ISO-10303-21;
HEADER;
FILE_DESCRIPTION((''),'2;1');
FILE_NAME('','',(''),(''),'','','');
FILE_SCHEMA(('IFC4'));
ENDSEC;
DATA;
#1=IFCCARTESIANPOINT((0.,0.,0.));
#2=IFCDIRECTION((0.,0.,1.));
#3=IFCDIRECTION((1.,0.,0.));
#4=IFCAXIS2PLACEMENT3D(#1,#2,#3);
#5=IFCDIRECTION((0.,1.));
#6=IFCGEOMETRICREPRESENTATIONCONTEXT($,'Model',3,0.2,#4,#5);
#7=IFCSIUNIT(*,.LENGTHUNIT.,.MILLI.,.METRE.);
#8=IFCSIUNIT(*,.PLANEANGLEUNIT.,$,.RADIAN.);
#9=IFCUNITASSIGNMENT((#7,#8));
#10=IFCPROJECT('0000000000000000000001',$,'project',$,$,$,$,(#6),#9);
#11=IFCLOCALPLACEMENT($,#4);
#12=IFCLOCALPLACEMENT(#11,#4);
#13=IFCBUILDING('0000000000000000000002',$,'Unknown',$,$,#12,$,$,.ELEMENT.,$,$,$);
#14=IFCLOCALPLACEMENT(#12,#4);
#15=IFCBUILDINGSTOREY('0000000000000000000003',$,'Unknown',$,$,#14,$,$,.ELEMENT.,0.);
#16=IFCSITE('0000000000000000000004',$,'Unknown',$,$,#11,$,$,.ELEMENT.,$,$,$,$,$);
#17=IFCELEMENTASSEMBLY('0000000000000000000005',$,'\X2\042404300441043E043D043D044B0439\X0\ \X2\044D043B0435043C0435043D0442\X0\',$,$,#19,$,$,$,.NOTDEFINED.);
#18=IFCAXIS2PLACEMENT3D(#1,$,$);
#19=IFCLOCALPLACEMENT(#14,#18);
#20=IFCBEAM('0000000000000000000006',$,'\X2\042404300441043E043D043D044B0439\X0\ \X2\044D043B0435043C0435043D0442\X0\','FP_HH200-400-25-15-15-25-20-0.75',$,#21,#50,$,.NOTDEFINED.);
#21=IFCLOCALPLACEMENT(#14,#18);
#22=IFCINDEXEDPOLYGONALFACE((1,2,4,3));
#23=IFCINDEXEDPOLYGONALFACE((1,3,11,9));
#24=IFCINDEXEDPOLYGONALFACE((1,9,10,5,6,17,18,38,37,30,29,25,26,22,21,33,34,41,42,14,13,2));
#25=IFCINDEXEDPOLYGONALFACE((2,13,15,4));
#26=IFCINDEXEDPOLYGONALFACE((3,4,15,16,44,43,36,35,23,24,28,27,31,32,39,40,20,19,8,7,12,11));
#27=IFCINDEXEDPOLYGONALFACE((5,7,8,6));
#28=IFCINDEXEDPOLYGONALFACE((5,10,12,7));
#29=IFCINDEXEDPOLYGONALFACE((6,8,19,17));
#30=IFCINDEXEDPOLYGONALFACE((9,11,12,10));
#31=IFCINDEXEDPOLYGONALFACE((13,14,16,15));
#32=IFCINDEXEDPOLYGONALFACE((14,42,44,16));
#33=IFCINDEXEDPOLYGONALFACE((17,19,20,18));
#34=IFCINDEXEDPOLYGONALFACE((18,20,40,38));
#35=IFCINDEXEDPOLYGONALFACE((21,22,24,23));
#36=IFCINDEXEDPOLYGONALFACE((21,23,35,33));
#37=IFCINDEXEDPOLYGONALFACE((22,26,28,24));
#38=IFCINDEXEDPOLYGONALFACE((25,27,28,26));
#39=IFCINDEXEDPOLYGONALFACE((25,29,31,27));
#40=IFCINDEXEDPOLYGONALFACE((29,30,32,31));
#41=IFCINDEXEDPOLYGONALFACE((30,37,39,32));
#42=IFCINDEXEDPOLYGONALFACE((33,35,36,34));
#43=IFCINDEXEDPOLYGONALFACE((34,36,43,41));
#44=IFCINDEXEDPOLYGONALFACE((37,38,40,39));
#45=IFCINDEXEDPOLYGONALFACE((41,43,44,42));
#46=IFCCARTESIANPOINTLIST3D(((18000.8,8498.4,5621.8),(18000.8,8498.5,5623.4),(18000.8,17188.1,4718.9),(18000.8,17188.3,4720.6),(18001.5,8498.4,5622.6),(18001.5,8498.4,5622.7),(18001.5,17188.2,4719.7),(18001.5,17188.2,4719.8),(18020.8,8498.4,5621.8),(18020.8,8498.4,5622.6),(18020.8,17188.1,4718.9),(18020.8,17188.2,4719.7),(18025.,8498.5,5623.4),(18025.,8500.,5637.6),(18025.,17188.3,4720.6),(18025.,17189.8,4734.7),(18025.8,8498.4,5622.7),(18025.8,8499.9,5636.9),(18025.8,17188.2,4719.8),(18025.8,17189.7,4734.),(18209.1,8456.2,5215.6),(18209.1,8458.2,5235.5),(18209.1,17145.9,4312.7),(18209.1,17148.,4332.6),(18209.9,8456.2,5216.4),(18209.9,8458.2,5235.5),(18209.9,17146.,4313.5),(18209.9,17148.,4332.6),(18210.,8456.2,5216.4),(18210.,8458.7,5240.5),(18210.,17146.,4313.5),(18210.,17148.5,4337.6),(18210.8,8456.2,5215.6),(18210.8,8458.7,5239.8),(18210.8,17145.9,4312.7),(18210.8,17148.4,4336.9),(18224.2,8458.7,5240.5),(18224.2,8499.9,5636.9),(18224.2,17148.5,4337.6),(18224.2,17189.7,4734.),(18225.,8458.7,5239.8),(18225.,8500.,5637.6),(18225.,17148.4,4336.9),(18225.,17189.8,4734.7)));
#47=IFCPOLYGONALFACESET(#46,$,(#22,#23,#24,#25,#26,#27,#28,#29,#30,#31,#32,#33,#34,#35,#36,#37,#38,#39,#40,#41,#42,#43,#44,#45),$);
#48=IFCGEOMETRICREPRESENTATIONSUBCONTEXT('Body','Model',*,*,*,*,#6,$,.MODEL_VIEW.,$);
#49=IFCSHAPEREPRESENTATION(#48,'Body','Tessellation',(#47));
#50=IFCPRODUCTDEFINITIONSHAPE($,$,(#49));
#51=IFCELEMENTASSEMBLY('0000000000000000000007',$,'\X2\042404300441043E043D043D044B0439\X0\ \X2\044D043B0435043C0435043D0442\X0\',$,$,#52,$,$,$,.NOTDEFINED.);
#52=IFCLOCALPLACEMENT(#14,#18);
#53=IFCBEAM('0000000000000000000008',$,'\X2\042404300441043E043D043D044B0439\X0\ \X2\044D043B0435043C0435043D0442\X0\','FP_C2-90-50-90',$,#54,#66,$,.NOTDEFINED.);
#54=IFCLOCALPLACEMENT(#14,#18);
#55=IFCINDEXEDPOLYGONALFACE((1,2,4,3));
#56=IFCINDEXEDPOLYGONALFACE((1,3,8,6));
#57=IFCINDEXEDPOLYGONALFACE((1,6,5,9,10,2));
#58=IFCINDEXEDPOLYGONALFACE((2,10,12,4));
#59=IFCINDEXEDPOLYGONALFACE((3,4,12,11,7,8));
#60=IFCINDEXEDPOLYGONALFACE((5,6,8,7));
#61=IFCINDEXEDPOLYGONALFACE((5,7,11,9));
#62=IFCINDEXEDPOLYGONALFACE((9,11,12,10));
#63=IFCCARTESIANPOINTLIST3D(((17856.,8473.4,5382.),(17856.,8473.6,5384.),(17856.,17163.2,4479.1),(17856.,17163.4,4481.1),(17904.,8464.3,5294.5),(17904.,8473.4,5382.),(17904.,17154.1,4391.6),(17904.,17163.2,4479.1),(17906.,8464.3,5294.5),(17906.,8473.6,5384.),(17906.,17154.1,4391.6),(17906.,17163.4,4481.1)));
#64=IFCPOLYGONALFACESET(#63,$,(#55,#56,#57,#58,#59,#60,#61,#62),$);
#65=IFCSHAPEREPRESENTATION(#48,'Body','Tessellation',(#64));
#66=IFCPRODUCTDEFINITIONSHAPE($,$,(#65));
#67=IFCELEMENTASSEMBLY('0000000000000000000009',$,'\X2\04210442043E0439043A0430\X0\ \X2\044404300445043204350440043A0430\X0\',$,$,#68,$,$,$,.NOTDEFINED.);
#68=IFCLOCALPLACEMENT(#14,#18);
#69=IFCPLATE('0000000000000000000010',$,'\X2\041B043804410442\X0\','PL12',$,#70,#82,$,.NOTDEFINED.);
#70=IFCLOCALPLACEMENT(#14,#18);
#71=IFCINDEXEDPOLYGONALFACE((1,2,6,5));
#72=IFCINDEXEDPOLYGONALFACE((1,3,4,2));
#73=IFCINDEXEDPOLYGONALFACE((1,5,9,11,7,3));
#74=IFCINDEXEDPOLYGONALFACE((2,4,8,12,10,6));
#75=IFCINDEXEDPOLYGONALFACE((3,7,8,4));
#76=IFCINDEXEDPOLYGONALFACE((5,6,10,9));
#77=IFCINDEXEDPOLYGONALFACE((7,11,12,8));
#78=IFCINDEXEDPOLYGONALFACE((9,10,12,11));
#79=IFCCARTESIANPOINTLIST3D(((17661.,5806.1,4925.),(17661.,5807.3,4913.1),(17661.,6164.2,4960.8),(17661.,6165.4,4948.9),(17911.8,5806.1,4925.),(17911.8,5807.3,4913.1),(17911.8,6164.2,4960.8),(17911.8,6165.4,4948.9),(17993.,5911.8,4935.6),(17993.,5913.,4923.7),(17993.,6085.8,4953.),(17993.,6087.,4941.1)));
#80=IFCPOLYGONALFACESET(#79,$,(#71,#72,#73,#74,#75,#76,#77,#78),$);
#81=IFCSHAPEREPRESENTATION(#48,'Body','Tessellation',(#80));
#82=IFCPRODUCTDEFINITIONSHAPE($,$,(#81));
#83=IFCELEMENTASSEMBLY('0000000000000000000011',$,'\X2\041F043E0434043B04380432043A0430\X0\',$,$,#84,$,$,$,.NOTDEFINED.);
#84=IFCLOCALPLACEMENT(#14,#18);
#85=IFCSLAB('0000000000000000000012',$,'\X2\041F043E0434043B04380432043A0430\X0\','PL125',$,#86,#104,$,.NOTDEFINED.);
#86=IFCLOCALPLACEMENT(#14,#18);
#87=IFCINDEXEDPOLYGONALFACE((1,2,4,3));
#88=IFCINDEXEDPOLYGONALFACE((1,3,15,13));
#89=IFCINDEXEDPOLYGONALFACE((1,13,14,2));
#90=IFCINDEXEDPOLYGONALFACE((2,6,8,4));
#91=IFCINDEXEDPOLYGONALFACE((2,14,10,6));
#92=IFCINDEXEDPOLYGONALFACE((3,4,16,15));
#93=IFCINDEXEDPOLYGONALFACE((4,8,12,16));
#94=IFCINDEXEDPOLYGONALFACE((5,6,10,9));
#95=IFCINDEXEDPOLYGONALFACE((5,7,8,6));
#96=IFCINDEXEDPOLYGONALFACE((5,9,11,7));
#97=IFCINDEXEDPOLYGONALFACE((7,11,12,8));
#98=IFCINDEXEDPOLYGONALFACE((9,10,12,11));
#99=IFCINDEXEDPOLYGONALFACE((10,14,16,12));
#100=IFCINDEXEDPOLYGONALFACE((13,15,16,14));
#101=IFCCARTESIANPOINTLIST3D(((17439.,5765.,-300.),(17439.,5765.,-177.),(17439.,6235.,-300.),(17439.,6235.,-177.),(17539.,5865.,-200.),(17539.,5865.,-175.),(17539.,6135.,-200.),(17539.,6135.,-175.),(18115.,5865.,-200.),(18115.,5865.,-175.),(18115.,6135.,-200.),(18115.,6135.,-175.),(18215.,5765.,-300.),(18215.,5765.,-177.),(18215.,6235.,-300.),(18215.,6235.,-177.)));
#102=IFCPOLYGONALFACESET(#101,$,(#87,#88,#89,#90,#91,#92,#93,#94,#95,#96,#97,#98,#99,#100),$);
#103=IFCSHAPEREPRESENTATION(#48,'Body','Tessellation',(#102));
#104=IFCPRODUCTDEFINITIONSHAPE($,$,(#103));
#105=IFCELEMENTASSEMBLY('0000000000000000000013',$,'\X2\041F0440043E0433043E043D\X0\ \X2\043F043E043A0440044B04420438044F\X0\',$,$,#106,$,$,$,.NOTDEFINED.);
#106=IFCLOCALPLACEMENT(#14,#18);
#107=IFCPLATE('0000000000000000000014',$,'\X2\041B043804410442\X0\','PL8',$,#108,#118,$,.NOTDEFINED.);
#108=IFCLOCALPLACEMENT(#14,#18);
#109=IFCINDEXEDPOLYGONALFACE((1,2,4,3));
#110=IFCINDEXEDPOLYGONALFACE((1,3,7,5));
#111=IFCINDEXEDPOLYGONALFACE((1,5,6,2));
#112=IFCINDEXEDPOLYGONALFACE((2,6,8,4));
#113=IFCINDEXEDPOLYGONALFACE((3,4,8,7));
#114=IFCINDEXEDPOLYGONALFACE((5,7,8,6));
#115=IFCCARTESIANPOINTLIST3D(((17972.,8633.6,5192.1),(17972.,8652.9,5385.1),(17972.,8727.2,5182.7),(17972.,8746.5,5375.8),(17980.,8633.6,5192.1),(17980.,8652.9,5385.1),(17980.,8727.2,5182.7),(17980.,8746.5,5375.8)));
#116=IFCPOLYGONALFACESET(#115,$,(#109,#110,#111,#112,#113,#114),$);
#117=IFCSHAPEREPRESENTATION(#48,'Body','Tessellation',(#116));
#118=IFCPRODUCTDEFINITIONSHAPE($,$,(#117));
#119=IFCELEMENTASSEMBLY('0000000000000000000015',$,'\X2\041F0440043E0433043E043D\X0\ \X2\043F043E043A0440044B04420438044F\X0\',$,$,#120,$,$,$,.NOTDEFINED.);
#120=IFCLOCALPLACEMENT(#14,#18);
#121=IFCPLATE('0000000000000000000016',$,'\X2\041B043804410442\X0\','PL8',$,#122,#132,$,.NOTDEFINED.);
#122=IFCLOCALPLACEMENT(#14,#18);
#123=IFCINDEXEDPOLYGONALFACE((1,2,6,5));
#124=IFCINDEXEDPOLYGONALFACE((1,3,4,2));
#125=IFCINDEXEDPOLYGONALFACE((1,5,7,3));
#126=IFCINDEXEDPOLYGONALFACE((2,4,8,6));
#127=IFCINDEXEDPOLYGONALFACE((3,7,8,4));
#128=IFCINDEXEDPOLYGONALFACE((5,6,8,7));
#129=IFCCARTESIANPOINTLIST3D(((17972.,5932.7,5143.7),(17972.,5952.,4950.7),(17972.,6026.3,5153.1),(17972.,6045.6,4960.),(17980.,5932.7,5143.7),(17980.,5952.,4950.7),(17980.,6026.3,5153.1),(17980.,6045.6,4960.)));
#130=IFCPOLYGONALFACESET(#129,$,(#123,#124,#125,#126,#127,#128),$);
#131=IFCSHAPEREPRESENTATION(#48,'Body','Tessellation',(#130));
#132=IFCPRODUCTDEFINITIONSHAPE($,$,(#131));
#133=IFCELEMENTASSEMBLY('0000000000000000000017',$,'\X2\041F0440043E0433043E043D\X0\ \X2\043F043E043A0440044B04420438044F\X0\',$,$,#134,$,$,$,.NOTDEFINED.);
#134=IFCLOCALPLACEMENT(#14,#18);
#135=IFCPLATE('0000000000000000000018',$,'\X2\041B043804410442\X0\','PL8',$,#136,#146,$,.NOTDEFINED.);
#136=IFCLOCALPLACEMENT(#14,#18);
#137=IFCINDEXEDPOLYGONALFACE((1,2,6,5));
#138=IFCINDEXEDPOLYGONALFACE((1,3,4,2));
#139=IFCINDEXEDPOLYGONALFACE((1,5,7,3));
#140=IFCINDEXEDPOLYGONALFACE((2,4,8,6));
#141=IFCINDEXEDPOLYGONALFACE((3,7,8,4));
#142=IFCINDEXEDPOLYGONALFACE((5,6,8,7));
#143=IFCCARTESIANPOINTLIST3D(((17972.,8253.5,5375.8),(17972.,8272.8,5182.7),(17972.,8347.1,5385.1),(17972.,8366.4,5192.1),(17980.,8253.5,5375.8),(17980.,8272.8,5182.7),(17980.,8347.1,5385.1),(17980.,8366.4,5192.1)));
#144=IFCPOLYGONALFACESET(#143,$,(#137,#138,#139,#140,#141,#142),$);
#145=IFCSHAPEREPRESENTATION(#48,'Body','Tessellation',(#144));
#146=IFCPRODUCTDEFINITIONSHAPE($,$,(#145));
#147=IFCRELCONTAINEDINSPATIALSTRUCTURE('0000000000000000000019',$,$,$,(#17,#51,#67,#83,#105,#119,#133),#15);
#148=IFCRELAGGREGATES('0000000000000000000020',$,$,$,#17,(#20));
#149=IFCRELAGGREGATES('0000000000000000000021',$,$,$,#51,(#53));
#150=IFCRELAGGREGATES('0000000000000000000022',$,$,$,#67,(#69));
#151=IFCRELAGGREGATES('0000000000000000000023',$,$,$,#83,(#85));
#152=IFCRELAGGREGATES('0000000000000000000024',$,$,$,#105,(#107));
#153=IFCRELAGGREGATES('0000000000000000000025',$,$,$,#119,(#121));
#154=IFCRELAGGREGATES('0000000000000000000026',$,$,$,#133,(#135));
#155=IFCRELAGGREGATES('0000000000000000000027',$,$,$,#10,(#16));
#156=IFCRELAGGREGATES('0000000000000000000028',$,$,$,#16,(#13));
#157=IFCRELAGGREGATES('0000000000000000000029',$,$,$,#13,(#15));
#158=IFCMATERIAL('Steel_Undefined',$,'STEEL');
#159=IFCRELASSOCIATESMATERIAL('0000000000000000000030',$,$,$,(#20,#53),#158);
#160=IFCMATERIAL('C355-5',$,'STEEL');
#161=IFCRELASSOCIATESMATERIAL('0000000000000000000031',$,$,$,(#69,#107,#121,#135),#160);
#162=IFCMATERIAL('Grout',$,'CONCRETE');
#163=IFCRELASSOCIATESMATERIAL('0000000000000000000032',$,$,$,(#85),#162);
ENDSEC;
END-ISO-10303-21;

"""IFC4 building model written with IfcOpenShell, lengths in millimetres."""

from ifc_helpers import new_model, si_unit, direction, frame, origin_with_axes, place, context, subcontext, project, spatial, line, indexed_curve, outline, extrude, material, element, aggregate, save


model = new_model("IFC4")

# Units and contexts
model_context = context("Model", 3, precision=0.2, world=origin_with_axes(), true_north=direction((0.0, 1.0)))
body_context = subcontext(model_context, "Body", "Model", "MODEL_VIEW")
ifc_project = project(units=[si_unit("LENGTHUNIT", "METRE", prefix="MILLI"), si_unit("PLANEANGLEUNIT", "RADIAN")], contexts=[model_context])

# Site, building, storey
site_placement = place(None, origin_with_axes())
site = spatial("IfcSite", under=ifc_project, at=site_placement, Name="Unknown", CompositionType="ELEMENT")
building_placement = place(site_placement, origin_with_axes())
building = spatial("IfcBuilding", under=site, at=building_placement, Name="Unknown", CompositionType="ELEMENT")
storey_placement = place(building_placement, origin_with_axes())
storey = spatial("IfcBuildingStorey", under=building, at=storey_placement, Name="Unknown", CompositionType="ELEMENT", Elevation=0.0)

# Shared definitions
ifc_material_1 = material(Name="C355-5", Category="STEEL")

# Element assemblies, beams
assembly_1_placement = place(storey_placement, frame((18125.0, 8479.3, 5438.7), z_axis=(0.0, 0.103345, 0.994646), x_axis=(0.0, 0.994646, -0.103345)))
assembly_1 = element("IfcElementAssembly", 1, at=assembly_1_placement, inside=storey, Name="Фасонный элемент", PredefinedType="NOTDEFINED")
ifc_material_2 = material(Name="Steel_Undefined", Category="STEEL")
beam_1_placement = place(assembly_1_placement, origin_with_axes())
beam_1 = element("IfcBeam", 2, at=beam_1_placement, material=ifc_material_2, Name="Фасонный элемент", Description="FP_HH200-400-25-15-15-25-20-0.75", PredefinedType="NOTDEFINED", context=body_context, shape_type="SolidModel", body=[
    extrude(outline(indexed_curve([(-200.0, -100.0), (200.0, -100.0), (200.0, 100.0), (185.8, 100.0), (185.8, 124.2), (184.1, 124.2), (184.1, 104.2), (184.9, 104.2), (184.9, 123.5), (185.0, 123.5), (185.0, 99.2), (199.2, 99.2), (199.2, -99.2), (-199.2, -99.2), (-199.2, -85.0), (-223.5, -85.0), (-223.5, -84.9), (-204.2, -84.9), (-204.2, -84.1), (-224.2, -84.1), (-224.2, -85.8), (-200.0, -85.8)], segments=[line(1, 2, 3, 4, 5, 6, 7, 8, 9, 10, 11, 12, 13, 14, 15, 16, 17, 18, 19, 20, 21, 22, 1)])), frame((0.0, 0.0, 0.0), z_axis=(-1.0, 0.0, 0.0), x_axis=(0.0, 0.0, 1.0)), (0.0, 0.0, -1.0), 8736.6),
])
aggregate(assembly_1, [beam_1])
assembly_2_placement = place(storey_placement, frame((17905.0, 8469.0, 5339.2), z_axis=(0.0, 0.103345, 0.994646), x_axis=(0.0, 0.994646, -0.103345)))
assembly_2 = element("IfcElementAssembly", 3, at=assembly_2_placement, inside=storey, Name="Фасонный элемент", PredefinedType="NOTDEFINED")
beam_2_placement = place(assembly_2_placement, origin_with_axes())
beam_2 = element("IfcBeam", 4, at=beam_2_placement, material=ifc_material_2, Name="Фасонный элемент", Description="FP_C2-90-50-90", PredefinedType="NOTDEFINED", context=body_context, shape_type="SolidModel", body=[
    extrude(outline(indexed_curve([(-45.0, -1.0), (45.0, -1.0), (45.0, 49.0), (43.0, 49.0), (43.0, 1.0), (-45.0, 1.0)], segments=[line(1, 2, 3, 4, 5, 6, 1)])), frame((0.0, 0.0, 0.0), z_axis=(-1.0, 0.0, 0.0), x_axis=(0.0, 0.0, 1.0)), (0.0, 0.0, -1.0), 8736.6),
])
aggregate(assembly_2, [beam_2])

# Element assembly, plate
assembly_3_placement = place(storey_placement, frame((17827.0, 6000.0, -200.0), z_axis=(0.0, -1.0, 0.0), x_axis=(0.0, 0.0, 1.0)))
assembly_3 = element("IfcElementAssembly", 5, at=assembly_3_placement, inside=storey, Name="Стойка фахверка", PredefinedType="NOTDEFINED")
plate_1_placement = place(assembly_3_placement, frame((5154.9, -166.0, -164.8), z_axis=(0.995037, 0.0, 0.099504), x_axis=(0.0, 1.0, 0.0)))
plate_1 = element("IfcPlate", 6, at=plate_1_placement, material=ifc_material_1, Name="Лист", Description="PL12", PredefinedType="NOTDEFINED", context=body_context, shape_type="SolidModel", body=[
    extrude(outline(indexed_curve([(0.0, 78.8), (81.2, 0.0), (332.0, 0.0), (332.0, 359.9), (81.2, 359.9), (0.0, 253.7)], segments=[line(1, 2, 3, 4, 5, 6, 1)])), frame((0.0, 0.0, 6.0), z_axis=(0.0, 0.0, 1.0), x_axis=(1.0, 0.0, 0.0)), (0.0, 0.0, -1.0), 12.0),
])
aggregate(assembly_3, [plate_1])

# Element assembly, slab, voiding features
assembly_4_placement = place(storey_placement, frame((18215.0, 6235.0, -237.5), z_axis=(0.0, 0.0, -1.0), x_axis=(0.0, -1.0, 0.0)))
assembly_4 = element("IfcElementAssembly", 7, at=assembly_4_placement, inside=storey, Name="Подливка", PredefinedType="NOTDEFINED")
ifc_material_3 = material(Name="Grout", Category="CONCRETE")
slab_placement = place(assembly_4_placement, origin_with_axes())
slab = element("IfcSlab", 8, at=slab_placement, material=ifc_material_3, Name="Подливка", Description="PL125", PredefinedType="NOTDEFINED", context=body_context, shape_type="SolidModel", body=[
    extrude(outline(indexed_curve([(0.0, 0.0), (470.0, 0.0), (470.0, 776.0), (0.0, 776.0)], segments=[line(1, 2, 3, 4, 1)])), frame((0.0, 0.0, 62.5), z_axis=(0.0, 0.0, 1.0), x_axis=(1.0, 0.0, 0.0)), (0.0, 0.0, -1.0), 125.0),
])
voiding_feature_1_placement = place(slab_placement, frame((235.0, 0.0, -62.5), z_axis=(1.0, 0.0, 0.0), x_axis=(0.0, 1.0, 0.0)))
element("IfcVoidingFeature", 9, at=voiding_feature_1_placement, cuts=slab, Name="PLATE", PredefinedType="HOLE", context=body_context, shape_type="SolidModel", body=[
    extrude(outline(indexed_curve([(0.0, 0.0), (100.0, 0.0), (0.0, 2.0)], segments=[line(1, 2, 3, 1)])), frame((0.0, 0.0, 247.0), z_axis=(0.0, 0.0, 1.0), x_axis=(1.0, 0.0, 0.0)), (0.0, 0.0, -1.0), 494.0),
])
voiding_feature_2_placement = place(slab_placement, frame((235.0, 776.0, -62.5), z_axis=(-1.0, 0.0, 0.0), x_axis=(0.0, -1.0, 0.0)))
element("IfcVoidingFeature", 10, at=voiding_feature_2_placement, cuts=slab, Name="PLATE", PredefinedType="HOLE", context=body_context, shape_type="SolidModel", body=[
    extrude(outline(indexed_curve([(0.0, 0.0), (100.0, 0.0), (0.0, 2.0)], segments=[line(1, 2, 3, 1)])), frame((0.0, 0.0, 247.0), z_axis=(0.0, 0.0, 1.0), x_axis=(1.0, 0.0, 0.0)), (0.0, 0.0, -1.0), 494.0),
])
voiding_feature_3_placement = place(slab_placement, frame((470.0, 388.0, -62.5), z_axis=(0.0, 1.0, 0.0), x_axis=(-1.0, 0.0, 0.0)))
element("IfcVoidingFeature", 11, at=voiding_feature_3_placement, cuts=slab, Name="PLATE", PredefinedType="HOLE", context=body_context, shape_type="SolidModel", body=[
    extrude(outline(indexed_curve([(0.0, 0.0), (100.0, 0.0), (0.0, 2.0)], segments=[line(1, 2, 3, 1)])), frame((0.0, 0.0, 400.0), z_axis=(0.0, 0.0, 1.0), x_axis=(1.0, 0.0, 0.0)), (0.0, 0.0, -1.0), 800.0),
])
voiding_feature_4_placement = place(slab_placement, frame((0.0, 388.0, -62.5), z_axis=(0.0, -1.0, 0.0), x_axis=(1.0, 0.0, 0.0)))
element("IfcVoidingFeature", 12, at=voiding_feature_4_placement, cuts=slab, Name="PLATE", PredefinedType="HOLE", context=body_context, shape_type="SolidModel", body=[
    extrude(outline(indexed_curve([(0.0, 0.0), (100.0, 0.0), (0.0, 2.0)], segments=[line(1, 2, 3, 1)])), frame((0.0, 0.0, 400.0), z_axis=(0.0, 0.0, 1.0), x_axis=(1.0, 0.0, 0.0)), (0.0, 0.0, -1.0), 800.0),
])
voiding_feature_5_placement = place(slab_placement, frame((235.0, 676.0, -50.0), z_axis=(0.0, 0.0, 1.0), x_axis=(0.0, -1.0, 0.0)))
element("IfcVoidingFeature", 13, at=voiding_feature_5_placement, cuts=slab, Name="Пластина", PredefinedType="HOLE", context=body_context, shape_type="SolidModel", body=[
    extrude(outline(indexed_curve([(-12.5, -135.0), (12.5, -135.0), (12.5, 135.0), (-12.5, 135.0)], segments=[line(1, 2, 3, 4, 1)])), frame((0.0, 0.0, 0.0), z_axis=(-1.0, 0.0, 0.0), x_axis=(0.0, 0.0, 1.0)), (0.0, 0.0, -1.0), 576.0),
])
aggregate(assembly_4, [slab])

# Element assembly, plate
assembly_5_placement = place(storey_placement, frame((18000.0, 8690.0, 5283.9), z_axis=(0.0, -0.995037, 0.099504), x_axis=(-1.0, 0.0, 0.0)))
assembly_5 = element("IfcElementAssembly", 14, at=assembly_5_placement, inside=storey, Name="Прогон покрытия", PredefinedType="NOTDEFINED")
plate_2_placement = place(assembly_5_placement, frame((24.0, 97.0, 47.0), z_axis=(-1.0, 0.0, 0.0), x_axis=(0.0, 0.0, -1.0)))
plate_2 = element("IfcPlate", 15, at=plate_2_placement, material=ifc_material_1, Name="Лист", Description="PL8", PredefinedType="NOTDEFINED", context=body_context, shape_type="SolidModel", body=[
    extrude(outline(indexed_curve([(0.0, 0.0), (94.0, 0.0), (94.0, 194.0), (0.0, 194.0)], segments=[line(1, 2, 3, 4, 1)])), frame((0.0, 0.0, 4.0), z_axis=(0.0, 0.0, 1.0), x_axis=(1.0, 0.0, 0.0)), (0.0, 0.0, -1.0), 8.0),
])
aggregate(assembly_5, [plate_2])

# Element assemblies, plates
assembly_6_placement = place(storey_placement, frame((12000.0, 5989.2, 5051.9), z_axis=(0.0, 0.995037, 0.099504), x_axis=(1.0, 0.0, 0.0)))
assembly_6 = element("IfcElementAssembly", 16, at=assembly_6_placement, inside=storey, Name="Прогон покрытия", PredefinedType="NOTDEFINED")
plate_3_placement = place(assembly_6_placement, frame((5976.0, -97.0, 47.0), z_axis=(1.0, 0.0, 0.0), x_axis=(0.0, 0.0, -1.0)))
plate_3 = element("IfcPlate", 17, at=plate_3_placement, material=ifc_material_1, Name="Лист", Description="PL8", PredefinedType="NOTDEFINED", context=body_context, shape_type="SolidModel", body=[
    extrude(outline(indexed_curve([(0.0, 0.0), (94.0, 0.0), (94.0, 194.0), (0.0, 194.0)], segments=[line(1, 2, 3, 4, 1)])), frame((0.0, 0.0, 4.0), z_axis=(0.0, 0.0, 1.0), x_axis=(1.0, 0.0, 0.0)), (0.0, 0.0, -1.0), 8.0),
])
aggregate(assembly_6, [plate_3])
assembly_7_placement = place(storey_placement, frame((12000.0, 8310.0, 5283.9), z_axis=(0.0, 0.995037, 0.099504), x_axis=(1.0, 0.0, 0.0)))
assembly_7 = element("IfcElementAssembly", 18, at=assembly_7_placement, inside=storey, Name="Прогон покрытия", PredefinedType="NOTDEFINED")
plate_4_placement = place(assembly_7_placement, frame((5976.0, -97.0, 47.0), z_axis=(1.0, 0.0, 0.0), x_axis=(0.0, 0.0, -1.0)))
plate_4 = element("IfcPlate", 19, at=plate_4_placement, material=ifc_material_1, Name="Лист", Description="PL8", PredefinedType="NOTDEFINED", context=body_context, shape_type="SolidModel", body=[
    extrude(outline(indexed_curve([(0.0, 0.0), (94.0, 0.0), (94.0, 194.0), (0.0, 194.0)], segments=[line(1, 2, 3, 4, 1)])), frame((0.0, 0.0, 4.0), z_axis=(0.0, 0.0, 1.0), x_axis=(1.0, 0.0, 0.0)), (0.0, 0.0, -1.0), 8.0),
])
aggregate(assembly_7, [plate_4])

save(model, "model.ifc")
